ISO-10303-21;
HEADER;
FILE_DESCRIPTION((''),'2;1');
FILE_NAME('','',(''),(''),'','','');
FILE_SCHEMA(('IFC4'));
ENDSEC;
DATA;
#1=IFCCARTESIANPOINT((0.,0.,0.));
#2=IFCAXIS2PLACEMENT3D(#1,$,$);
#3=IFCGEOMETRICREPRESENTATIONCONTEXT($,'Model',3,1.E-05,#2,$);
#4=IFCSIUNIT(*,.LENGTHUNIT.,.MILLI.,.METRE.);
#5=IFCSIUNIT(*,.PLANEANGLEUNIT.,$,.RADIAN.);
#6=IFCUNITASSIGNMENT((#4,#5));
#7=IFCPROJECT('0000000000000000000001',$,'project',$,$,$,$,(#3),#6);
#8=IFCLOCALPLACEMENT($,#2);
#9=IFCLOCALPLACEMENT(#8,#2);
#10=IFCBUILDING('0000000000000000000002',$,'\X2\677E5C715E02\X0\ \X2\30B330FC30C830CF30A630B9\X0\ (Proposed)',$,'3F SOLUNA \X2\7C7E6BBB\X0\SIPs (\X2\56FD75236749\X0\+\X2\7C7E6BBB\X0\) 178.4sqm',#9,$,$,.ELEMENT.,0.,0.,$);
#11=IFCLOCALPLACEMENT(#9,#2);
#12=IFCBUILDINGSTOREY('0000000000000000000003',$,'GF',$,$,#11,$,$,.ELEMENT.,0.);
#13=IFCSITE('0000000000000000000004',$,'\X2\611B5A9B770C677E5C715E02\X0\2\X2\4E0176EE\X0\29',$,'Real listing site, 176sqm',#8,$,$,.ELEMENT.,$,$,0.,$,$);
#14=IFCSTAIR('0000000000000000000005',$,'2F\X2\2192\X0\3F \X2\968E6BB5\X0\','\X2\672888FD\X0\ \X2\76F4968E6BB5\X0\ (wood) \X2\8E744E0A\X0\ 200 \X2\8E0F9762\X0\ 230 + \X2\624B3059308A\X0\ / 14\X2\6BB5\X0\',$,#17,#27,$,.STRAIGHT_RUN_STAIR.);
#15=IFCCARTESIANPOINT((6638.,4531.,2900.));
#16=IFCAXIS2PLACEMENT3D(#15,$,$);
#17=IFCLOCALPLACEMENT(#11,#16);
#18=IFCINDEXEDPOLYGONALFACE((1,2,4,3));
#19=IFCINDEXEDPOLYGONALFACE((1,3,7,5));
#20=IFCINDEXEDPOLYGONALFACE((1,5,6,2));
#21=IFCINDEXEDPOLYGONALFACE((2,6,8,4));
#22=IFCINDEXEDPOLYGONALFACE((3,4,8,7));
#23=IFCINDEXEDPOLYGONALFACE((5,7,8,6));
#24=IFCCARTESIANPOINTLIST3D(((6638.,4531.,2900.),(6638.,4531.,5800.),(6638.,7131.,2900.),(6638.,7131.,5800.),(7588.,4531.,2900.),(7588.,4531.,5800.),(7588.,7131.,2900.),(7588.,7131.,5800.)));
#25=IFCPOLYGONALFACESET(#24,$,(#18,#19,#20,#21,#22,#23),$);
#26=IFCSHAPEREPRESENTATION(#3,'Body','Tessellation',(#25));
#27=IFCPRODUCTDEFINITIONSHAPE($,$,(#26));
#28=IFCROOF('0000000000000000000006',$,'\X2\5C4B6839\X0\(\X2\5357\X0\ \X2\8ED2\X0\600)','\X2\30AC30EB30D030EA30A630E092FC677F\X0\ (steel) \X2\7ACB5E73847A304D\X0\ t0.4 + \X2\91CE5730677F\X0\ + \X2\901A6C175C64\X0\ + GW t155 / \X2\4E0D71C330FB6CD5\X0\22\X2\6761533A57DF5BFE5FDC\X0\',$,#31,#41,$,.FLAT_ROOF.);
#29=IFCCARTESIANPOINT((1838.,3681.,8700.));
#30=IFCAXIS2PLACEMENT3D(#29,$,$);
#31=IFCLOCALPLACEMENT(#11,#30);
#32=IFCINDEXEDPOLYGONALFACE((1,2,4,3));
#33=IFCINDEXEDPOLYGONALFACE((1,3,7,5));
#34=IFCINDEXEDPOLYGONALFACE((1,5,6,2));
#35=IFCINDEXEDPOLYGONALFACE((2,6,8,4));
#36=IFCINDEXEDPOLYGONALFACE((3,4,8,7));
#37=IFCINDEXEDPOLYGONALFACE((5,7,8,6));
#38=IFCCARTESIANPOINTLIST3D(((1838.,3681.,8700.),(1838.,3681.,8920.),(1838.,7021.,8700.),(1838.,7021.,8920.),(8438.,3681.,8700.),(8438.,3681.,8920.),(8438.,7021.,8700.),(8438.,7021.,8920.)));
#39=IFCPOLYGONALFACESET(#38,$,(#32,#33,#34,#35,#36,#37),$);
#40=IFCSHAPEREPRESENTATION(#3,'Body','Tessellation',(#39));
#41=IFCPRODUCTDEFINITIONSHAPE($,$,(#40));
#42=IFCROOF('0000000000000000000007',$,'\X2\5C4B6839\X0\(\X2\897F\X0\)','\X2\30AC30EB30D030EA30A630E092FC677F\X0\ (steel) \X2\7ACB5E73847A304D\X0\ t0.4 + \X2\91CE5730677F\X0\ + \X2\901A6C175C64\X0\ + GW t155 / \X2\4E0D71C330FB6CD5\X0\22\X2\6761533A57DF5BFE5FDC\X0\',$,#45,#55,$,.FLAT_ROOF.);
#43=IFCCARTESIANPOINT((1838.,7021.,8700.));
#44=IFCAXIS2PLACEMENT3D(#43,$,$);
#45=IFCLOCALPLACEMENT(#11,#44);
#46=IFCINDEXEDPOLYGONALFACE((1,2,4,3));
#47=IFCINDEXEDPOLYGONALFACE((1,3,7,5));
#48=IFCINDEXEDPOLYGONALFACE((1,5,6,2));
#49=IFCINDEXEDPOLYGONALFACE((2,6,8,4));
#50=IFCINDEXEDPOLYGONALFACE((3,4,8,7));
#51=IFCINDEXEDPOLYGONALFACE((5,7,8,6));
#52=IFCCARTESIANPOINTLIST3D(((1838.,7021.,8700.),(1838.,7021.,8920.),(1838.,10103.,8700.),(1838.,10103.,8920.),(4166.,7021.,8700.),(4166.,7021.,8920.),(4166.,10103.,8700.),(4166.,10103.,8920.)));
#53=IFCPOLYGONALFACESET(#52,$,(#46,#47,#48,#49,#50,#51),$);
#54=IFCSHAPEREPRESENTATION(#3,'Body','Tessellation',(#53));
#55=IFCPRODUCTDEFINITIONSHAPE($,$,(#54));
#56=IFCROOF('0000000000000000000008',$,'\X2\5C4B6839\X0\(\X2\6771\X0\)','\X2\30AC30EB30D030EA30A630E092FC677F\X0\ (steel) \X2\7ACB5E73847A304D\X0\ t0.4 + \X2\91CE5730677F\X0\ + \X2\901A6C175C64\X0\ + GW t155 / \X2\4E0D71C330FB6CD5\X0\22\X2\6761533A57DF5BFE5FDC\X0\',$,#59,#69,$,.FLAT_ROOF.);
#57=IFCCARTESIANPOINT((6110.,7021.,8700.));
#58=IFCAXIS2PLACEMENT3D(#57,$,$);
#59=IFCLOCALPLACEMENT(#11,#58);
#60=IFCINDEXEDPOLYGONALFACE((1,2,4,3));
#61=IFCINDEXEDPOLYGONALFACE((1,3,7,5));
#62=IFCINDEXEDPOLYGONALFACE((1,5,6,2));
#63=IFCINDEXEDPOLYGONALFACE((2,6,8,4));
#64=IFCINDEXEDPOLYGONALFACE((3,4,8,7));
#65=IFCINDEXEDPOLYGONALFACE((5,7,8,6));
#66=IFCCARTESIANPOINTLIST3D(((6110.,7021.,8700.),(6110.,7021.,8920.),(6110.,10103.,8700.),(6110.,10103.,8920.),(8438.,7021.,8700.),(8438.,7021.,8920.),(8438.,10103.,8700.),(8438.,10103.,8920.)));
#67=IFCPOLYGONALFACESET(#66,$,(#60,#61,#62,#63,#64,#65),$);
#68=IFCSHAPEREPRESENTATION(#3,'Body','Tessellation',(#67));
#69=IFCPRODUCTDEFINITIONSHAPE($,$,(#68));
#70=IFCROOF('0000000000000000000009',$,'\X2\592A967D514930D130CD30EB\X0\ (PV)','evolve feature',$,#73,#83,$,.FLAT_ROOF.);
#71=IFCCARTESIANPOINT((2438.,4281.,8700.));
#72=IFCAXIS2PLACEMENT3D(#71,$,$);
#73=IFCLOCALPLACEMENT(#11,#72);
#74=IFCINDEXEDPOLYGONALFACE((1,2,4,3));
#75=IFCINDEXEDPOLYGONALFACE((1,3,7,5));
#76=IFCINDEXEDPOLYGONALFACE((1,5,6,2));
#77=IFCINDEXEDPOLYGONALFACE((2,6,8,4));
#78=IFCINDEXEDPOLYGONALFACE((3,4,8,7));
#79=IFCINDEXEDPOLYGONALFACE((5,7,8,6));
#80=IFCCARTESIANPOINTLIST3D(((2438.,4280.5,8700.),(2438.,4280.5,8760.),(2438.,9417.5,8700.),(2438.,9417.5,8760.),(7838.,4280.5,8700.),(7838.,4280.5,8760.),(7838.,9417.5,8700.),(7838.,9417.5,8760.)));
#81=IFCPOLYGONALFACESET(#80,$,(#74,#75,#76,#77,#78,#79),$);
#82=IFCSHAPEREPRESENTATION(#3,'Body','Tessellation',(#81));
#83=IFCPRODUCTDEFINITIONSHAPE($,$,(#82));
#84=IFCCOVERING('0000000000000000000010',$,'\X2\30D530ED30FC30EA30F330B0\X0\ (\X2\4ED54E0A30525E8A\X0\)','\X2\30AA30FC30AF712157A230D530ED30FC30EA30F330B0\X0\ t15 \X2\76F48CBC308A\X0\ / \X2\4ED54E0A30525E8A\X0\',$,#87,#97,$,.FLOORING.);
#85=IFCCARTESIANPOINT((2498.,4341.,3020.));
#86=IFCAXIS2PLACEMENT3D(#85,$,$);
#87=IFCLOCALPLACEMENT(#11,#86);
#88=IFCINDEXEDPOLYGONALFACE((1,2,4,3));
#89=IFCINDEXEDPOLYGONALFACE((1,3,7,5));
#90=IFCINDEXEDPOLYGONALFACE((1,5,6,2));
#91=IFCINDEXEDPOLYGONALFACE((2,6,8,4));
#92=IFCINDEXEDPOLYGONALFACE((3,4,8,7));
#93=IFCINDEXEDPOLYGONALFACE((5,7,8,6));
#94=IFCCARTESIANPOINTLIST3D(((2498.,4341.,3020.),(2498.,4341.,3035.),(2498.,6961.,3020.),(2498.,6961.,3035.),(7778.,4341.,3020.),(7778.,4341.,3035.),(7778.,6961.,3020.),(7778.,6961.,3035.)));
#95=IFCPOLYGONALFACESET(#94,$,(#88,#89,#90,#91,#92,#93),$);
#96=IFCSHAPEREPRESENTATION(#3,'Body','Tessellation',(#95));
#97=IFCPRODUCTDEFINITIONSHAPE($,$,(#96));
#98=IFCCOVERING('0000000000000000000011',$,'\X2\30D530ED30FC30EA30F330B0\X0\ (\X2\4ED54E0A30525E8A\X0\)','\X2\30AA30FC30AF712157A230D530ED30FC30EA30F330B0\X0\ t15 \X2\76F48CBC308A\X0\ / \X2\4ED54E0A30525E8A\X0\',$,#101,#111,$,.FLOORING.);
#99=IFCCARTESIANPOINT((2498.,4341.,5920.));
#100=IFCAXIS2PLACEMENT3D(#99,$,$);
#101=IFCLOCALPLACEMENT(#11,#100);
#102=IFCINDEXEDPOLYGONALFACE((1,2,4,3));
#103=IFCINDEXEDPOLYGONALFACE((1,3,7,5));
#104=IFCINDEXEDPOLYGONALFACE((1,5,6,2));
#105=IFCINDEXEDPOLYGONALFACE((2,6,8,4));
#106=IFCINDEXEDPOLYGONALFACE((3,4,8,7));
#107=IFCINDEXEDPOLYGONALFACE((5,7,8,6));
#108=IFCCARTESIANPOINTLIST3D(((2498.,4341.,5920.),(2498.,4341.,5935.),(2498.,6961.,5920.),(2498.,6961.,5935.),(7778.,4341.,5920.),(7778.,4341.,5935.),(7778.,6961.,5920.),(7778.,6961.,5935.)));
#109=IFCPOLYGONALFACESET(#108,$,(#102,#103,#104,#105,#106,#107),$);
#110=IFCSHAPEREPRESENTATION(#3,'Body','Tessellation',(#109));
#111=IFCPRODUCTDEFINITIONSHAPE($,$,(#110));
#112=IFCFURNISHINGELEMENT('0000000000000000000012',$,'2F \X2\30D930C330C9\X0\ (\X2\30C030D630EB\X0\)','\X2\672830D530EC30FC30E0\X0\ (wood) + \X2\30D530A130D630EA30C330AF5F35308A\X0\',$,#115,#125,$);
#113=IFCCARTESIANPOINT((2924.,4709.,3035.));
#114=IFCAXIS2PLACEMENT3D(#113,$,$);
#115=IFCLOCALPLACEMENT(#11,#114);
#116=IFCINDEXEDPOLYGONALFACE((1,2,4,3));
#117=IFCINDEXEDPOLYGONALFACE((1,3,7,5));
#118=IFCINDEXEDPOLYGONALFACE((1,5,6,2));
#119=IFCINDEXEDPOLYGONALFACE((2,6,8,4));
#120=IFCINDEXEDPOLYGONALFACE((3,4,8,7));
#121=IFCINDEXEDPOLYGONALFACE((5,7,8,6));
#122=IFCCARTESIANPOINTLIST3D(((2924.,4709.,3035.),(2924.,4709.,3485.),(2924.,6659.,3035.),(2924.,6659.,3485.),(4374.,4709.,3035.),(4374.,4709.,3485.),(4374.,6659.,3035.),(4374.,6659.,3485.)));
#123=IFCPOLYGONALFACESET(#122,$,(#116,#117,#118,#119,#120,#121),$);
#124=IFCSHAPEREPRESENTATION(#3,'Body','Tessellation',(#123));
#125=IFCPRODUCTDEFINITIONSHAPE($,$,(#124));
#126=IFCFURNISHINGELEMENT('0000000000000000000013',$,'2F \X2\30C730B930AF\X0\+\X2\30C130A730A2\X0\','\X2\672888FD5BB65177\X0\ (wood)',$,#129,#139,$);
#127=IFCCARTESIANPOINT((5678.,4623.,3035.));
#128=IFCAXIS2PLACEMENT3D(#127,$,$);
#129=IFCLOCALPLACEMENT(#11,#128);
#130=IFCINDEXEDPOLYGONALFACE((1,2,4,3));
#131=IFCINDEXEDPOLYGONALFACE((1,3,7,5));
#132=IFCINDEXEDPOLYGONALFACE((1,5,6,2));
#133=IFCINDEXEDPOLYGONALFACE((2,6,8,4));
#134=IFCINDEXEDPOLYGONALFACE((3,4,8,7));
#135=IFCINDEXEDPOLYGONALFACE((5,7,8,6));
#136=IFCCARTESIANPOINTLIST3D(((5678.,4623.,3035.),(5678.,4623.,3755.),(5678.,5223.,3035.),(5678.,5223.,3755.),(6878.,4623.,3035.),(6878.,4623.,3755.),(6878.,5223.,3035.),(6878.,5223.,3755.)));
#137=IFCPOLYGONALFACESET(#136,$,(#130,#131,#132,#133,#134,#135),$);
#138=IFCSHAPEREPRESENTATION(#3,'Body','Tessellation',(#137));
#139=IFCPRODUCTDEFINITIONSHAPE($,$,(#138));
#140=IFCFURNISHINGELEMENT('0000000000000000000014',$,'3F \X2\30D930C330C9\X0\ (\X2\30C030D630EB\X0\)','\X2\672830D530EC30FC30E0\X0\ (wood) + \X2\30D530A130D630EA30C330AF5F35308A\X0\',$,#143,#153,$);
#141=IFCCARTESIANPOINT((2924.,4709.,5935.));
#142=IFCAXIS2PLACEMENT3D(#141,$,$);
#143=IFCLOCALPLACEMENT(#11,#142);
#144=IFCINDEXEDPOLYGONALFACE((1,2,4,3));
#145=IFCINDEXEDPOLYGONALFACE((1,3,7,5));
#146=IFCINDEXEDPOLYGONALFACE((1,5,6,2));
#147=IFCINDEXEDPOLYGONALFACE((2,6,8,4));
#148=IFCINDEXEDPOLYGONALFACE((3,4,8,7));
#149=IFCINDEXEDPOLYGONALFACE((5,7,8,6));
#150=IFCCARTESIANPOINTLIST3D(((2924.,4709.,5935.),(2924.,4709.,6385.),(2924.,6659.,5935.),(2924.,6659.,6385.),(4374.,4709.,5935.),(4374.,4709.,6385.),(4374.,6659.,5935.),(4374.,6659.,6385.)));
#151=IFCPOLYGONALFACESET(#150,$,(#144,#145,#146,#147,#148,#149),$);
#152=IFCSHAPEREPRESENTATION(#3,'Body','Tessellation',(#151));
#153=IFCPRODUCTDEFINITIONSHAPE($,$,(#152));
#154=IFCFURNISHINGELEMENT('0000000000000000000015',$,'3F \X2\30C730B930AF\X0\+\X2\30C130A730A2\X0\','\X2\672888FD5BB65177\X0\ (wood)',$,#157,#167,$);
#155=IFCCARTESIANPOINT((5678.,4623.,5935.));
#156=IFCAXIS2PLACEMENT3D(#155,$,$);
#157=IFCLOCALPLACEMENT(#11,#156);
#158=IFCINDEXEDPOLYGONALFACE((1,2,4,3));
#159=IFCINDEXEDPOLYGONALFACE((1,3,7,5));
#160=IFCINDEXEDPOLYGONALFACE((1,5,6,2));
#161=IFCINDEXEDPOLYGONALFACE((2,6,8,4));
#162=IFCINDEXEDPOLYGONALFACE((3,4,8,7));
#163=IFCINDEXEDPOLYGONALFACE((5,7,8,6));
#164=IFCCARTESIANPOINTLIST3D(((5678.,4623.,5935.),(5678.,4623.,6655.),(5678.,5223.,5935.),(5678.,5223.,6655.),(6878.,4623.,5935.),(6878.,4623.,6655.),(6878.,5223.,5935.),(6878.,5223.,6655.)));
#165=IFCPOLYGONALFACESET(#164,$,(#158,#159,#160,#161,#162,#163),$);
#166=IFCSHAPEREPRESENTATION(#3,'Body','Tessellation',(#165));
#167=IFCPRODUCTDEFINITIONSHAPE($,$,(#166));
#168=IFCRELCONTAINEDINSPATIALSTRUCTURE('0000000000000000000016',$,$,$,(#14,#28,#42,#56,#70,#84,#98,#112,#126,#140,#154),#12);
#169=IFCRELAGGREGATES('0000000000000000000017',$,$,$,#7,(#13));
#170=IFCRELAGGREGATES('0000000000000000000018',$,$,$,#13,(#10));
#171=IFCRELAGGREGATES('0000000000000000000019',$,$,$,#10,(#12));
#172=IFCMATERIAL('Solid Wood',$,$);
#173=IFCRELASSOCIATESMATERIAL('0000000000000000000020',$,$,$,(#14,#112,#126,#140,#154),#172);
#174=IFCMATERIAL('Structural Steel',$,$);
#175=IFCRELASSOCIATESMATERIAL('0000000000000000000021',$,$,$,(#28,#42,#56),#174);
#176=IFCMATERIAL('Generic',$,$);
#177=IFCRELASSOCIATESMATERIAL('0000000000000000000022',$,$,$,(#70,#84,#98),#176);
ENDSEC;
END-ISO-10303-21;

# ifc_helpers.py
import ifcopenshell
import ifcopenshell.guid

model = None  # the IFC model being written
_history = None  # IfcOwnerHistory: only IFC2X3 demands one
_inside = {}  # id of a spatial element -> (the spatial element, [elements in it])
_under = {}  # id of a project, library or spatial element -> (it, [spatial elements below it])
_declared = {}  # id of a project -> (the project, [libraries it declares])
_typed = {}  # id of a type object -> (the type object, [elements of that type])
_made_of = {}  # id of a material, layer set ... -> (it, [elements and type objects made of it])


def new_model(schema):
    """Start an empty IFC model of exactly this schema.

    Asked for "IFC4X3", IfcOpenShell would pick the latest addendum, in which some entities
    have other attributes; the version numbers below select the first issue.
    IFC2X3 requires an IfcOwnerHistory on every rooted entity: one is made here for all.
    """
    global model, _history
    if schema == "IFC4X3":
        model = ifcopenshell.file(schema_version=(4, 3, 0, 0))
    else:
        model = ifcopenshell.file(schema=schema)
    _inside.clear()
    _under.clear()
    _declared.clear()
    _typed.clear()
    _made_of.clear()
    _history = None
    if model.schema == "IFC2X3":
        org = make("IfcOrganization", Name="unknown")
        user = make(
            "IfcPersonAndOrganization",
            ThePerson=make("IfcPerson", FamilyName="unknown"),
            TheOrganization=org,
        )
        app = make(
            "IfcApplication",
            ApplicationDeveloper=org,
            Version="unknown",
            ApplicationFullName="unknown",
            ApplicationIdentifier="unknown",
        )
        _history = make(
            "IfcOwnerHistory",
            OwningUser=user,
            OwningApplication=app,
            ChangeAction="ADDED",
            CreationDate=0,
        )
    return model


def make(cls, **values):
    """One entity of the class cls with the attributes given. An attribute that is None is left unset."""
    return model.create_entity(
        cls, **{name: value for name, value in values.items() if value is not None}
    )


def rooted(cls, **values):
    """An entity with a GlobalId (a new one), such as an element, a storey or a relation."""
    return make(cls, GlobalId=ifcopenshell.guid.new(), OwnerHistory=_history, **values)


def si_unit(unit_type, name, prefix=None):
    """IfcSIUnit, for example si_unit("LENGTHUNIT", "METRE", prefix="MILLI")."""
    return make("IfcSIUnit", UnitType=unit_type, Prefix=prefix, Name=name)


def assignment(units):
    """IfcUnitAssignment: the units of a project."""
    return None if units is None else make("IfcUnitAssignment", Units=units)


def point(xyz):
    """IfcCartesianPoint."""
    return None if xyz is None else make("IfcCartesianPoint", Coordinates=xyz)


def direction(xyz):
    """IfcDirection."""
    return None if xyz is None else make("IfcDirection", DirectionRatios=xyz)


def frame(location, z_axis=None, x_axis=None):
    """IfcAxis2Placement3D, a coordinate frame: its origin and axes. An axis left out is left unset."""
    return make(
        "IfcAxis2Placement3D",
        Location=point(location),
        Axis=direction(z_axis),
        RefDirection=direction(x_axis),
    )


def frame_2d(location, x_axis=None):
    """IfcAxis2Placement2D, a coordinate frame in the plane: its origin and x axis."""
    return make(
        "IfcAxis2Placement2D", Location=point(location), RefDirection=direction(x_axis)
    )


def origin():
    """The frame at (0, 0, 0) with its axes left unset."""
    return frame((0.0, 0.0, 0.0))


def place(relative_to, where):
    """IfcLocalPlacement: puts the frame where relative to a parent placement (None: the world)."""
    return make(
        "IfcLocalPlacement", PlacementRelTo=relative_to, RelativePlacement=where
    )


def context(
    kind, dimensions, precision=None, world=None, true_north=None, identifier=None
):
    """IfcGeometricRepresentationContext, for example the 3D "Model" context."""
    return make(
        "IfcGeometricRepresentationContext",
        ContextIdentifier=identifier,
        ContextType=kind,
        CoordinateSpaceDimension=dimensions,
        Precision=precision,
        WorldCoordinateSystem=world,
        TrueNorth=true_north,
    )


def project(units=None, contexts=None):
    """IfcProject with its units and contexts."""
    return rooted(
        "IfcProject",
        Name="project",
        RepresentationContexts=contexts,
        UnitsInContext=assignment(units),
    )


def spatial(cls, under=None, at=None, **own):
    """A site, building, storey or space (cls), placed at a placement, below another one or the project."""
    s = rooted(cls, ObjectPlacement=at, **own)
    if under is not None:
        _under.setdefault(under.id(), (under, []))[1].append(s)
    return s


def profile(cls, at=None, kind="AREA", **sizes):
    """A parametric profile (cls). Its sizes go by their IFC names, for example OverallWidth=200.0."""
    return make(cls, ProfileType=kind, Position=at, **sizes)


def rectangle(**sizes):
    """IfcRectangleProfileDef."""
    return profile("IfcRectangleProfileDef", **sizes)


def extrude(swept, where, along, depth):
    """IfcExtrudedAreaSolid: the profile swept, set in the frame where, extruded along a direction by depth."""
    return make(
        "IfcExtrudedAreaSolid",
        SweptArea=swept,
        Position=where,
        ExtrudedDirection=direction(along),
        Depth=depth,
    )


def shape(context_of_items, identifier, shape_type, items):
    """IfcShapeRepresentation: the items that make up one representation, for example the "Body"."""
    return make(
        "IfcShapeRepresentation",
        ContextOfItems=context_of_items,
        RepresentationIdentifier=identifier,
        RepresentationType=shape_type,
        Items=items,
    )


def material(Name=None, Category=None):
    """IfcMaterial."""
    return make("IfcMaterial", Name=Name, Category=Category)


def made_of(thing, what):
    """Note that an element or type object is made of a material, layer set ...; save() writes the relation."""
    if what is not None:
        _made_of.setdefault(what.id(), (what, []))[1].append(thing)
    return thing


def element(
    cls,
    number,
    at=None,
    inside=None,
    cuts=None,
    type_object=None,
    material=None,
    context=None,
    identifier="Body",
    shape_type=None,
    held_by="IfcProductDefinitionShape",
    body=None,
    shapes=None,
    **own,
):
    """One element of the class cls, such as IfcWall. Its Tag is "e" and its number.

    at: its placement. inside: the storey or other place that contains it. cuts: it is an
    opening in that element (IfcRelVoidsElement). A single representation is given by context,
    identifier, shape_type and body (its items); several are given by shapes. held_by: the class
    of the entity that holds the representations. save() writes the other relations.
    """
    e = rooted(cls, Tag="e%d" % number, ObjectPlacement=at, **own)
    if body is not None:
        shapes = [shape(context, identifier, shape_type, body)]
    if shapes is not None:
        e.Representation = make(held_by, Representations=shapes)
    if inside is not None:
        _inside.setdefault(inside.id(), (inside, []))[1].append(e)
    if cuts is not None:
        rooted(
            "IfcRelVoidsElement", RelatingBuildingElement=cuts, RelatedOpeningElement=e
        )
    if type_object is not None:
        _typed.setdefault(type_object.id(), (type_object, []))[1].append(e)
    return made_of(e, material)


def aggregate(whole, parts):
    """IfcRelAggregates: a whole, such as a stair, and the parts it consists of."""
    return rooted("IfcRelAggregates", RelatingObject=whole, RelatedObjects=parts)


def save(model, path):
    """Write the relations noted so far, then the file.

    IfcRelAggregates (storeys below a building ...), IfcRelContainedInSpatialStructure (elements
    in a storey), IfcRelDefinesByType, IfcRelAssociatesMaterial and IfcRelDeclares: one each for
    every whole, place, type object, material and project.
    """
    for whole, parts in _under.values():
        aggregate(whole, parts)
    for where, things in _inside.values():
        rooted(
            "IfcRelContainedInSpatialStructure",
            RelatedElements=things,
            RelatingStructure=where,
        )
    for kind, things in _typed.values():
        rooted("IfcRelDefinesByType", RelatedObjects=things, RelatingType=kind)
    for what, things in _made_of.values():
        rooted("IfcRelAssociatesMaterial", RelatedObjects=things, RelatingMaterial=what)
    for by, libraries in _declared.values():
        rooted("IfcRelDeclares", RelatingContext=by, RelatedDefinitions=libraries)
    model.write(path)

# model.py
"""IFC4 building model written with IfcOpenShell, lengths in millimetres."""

from ifc_helpers import new_model, si_unit, frame, frame_2d, origin, place, context, project, spatial, rectangle, extrude, material, element, save


model = new_model("IFC4")

# Units and contexts
model_context = context("Model", 3, precision=1e-05, world=origin())
ifc_project = project(units=[si_unit("LENGTHUNIT", "METRE", prefix="MILLI"), si_unit("PLANEANGLEUNIT", "RADIAN")], contexts=[model_context])

# Site, building, storey
site_placement = place(None, origin())
site = spatial("IfcSite", under=ifc_project, at=site_placement, Name="愛媛県松山市2丁目29", ObjectType="Real listing site, 176sqm", CompositionType="ELEMENT", RefElevation=0.0)
building_placement = place(site_placement, origin())
building = spatial("IfcBuilding", under=site, at=building_placement, Name="松山市 コートハウス (Proposed)", ObjectType="3F SOLUNA 籾殻SIPs (国産杉+籾殻) 178.4sqm", CompositionType="ELEMENT", ElevationOfRefHeight=0.0, ElevationOfTerrain=0.0)
storey_placement = place(building_placement, origin())
storey = spatial("IfcBuildingStorey", under=building, at=storey_placement, Name="GF", CompositionType="ELEMENT", Elevation=0.0)

# Shared definitions
ifc_material_1 = material(Name="Solid Wood")

# Stair
stair_placement = place(storey_placement, frame((6638.0, 4531.0, 2900.0)))
element("IfcStair", 1, at=stair_placement, inside=storey, material=ifc_material_1, Name="2F→3F 階段", Description="木製 直階段 (wood) 蹴上 200 踏面 230 + 手すり / 14段", PredefinedType="STRAIGHT_RUN_STAIR", context=model_context, shape_type="SweptSolid", body=[
    extrude(rectangle(XDim=950.0, YDim=2600.0, at=frame_2d((475.0, 1300.0))), frame((6638.0, 4531.0, 2900.0)), (0.0, 0.0, 1.0), 2900.0),
])

# Roofs
ifc_material_2 = material(Name="Structural Steel")
roof_1_placement = place(storey_placement, frame((1838.0, 3681.0, 8700.0)))
element("IfcRoof", 2, at=roof_1_placement, inside=storey, material=ifc_material_2, Name="屋根(南 軒600)", Description="ガルバリウム鋼板 (steel) 立平葺き t0.4 + 野地板 + 通気層 + GW t155 / 不燃・法22条区域対応", PredefinedType="FLAT_ROOF", context=model_context, shape_type="SweptSolid", body=[
    extrude(rectangle(XDim=6600.0, YDim=3340.0, at=frame_2d((3300.0, 1670.0))), frame((1838.0, 3681.0, 8700.0)), (0.0, 0.0, 1.0), 220.0),
])
roof_2_placement = place(storey_placement, frame((1838.0, 7021.0, 8700.0)))
element("IfcRoof", 3, at=roof_2_placement, inside=storey, material=ifc_material_2, Name="屋根(西)", Description="ガルバリウム鋼板 (steel) 立平葺き t0.4 + 野地板 + 通気層 + GW t155 / 不燃・法22条区域対応", PredefinedType="FLAT_ROOF", context=model_context, shape_type="SweptSolid", body=[
    extrude(rectangle(XDim=2328.0, YDim=3082.0, at=frame_2d((1164.0, 1541.0))), frame((1838.0, 7021.0, 8700.0)), (0.0, 0.0, 1.0), 220.0),
])
roof_3_placement = place(storey_placement, frame((6110.0, 7021.0, 8700.0)))
element("IfcRoof", 4, at=roof_3_placement, inside=storey, material=ifc_material_2, Name="屋根(東)", Description="ガルバリウム鋼板 (steel) 立平葺き t0.4 + 野地板 + 通気層 + GW t155 / 不燃・法22条区域対応", PredefinedType="FLAT_ROOF", context=model_context, shape_type="SweptSolid", body=[
    extrude(rectangle(XDim=2328.0, YDim=3082.0, at=frame_2d((1164.0, 1541.0))), frame((6110.0, 7021.0, 8700.0)), (0.0, 0.0, 1.0), 220.0),
])
ifc_material_3 = material(Name="Generic")
roof_4_placement = place(storey_placement, frame((2438.0, 4281.0, 8700.0)))
element("IfcRoof", 5, at=roof_4_placement, inside=storey, material=ifc_material_3, Name="太陽光パネル (PV)", Description="evolve feature", PredefinedType="FLAT_ROOF", context=model_context, shape_type="SweptSolid", body=[
    extrude(rectangle(XDim=5400.0, YDim=5137.0, at=frame_2d((2700.0, 2568.0))), frame((2438.0, 4281.0, 8700.0)), (0.0, 0.0, 1.0), 60.0),
])

# Coverings
covering_1_placement = place(storey_placement, frame((2498.0, 4341.0, 3020.0)))
element("IfcCovering", 6, at=covering_1_placement, inside=storey, material=ifc_material_3, Name="フローリング (仕上げ床)", Description="オーク無垢フローリング t15 直貼り / 仕上げ床", PredefinedType="FLOORING", context=model_context, shape_type="SweptSolid", body=[
    extrude(rectangle(XDim=5280.0, YDim=2620.0, at=frame_2d((2640.0, 1310.0))), frame((2498.0, 4341.0, 3020.0)), (0.0, 0.0, 1.0), 15.0),
])
covering_2_placement = place(storey_placement, frame((2498.0, 4341.0, 5920.0)))
element("IfcCovering", 7, at=covering_2_placement, inside=storey, material=ifc_material_3, Name="フローリング (仕上げ床)", Description="オーク無垢フローリング t15 直貼り / 仕上げ床", PredefinedType="FLOORING", context=model_context, shape_type="SweptSolid", body=[
    extrude(rectangle(XDim=5280.0, YDim=2620.0, at=frame_2d((2640.0, 1310.0))), frame((2498.0, 4341.0, 5920.0)), (0.0, 0.0, 1.0), 15.0),
])

# Furnishing elements
furnishing_1_placement = place(storey_placement, frame((2924.0, 4709.0, 3035.0)))
element("IfcFurnishingElement", 8, at=furnishing_1_placement, inside=storey, material=ifc_material_1, Name="2F ベッド (ダブル)", Description="木フレーム (wood) + ファブリック張り", context=model_context, shape_type="SweptSolid", body=[
    extrude(rectangle(XDim=1450.0, YDim=1950.0, at=frame_2d((725.0, 975.0))), frame((2924.0, 4709.0, 3035.0)), (0.0, 0.0, 1.0), 450.0),
])
furnishing_2_placement = place(storey_placement, frame((5678.0, 4623.0, 3035.0)))
element("IfcFurnishingElement", 9, at=furnishing_2_placement, inside=storey, material=ifc_material_1, Name="2F デスク+チェア", Description="木製家具 (wood)", context=model_context, shape_type="SweptSolid", body=[
    extrude(rectangle(XDim=1200.0, YDim=600.0, at=frame_2d((600.0, 300.0))), frame((5678.0, 4623.0, 3035.0)), (0.0, 0.0, 1.0), 720.0),
])
furnishing_3_placement = place(storey_placement, frame((2924.0, 4709.0, 5935.0)))
element("IfcFurnishingElement", 10, at=furnishing_3_placement, inside=storey, material=ifc_material_1, Name="3F ベッド (ダブル)", Description="木フレーム (wood) + ファブリック張り", context=model_context, shape_type="SweptSolid", body=[
    extrude(rectangle(XDim=1450.0, YDim=1950.0, at=frame_2d((725.0, 975.0))), frame((2924.0, 4709.0, 5935.0)), (0.0, 0.0, 1.0), 450.0),
])
furnishing_4_placement = place(storey_placement, frame((5678.0, 4623.0, 5935.0)))
element("IfcFurnishingElement", 11, at=furnishing_4_placement, inside=storey, material=ifc_material_1, Name="3F デスク+チェア", Description="木製家具 (wood)", context=model_context, shape_type="SweptSolid", body=[
    extrude(rectangle(XDim=1200.0, YDim=600.0, at=frame_2d((600.0, 300.0))), frame((5678.0, 4623.0, 5935.0)), (0.0, 0.0, 1.0), 720.0),
])

save(model, "model.ifc")
